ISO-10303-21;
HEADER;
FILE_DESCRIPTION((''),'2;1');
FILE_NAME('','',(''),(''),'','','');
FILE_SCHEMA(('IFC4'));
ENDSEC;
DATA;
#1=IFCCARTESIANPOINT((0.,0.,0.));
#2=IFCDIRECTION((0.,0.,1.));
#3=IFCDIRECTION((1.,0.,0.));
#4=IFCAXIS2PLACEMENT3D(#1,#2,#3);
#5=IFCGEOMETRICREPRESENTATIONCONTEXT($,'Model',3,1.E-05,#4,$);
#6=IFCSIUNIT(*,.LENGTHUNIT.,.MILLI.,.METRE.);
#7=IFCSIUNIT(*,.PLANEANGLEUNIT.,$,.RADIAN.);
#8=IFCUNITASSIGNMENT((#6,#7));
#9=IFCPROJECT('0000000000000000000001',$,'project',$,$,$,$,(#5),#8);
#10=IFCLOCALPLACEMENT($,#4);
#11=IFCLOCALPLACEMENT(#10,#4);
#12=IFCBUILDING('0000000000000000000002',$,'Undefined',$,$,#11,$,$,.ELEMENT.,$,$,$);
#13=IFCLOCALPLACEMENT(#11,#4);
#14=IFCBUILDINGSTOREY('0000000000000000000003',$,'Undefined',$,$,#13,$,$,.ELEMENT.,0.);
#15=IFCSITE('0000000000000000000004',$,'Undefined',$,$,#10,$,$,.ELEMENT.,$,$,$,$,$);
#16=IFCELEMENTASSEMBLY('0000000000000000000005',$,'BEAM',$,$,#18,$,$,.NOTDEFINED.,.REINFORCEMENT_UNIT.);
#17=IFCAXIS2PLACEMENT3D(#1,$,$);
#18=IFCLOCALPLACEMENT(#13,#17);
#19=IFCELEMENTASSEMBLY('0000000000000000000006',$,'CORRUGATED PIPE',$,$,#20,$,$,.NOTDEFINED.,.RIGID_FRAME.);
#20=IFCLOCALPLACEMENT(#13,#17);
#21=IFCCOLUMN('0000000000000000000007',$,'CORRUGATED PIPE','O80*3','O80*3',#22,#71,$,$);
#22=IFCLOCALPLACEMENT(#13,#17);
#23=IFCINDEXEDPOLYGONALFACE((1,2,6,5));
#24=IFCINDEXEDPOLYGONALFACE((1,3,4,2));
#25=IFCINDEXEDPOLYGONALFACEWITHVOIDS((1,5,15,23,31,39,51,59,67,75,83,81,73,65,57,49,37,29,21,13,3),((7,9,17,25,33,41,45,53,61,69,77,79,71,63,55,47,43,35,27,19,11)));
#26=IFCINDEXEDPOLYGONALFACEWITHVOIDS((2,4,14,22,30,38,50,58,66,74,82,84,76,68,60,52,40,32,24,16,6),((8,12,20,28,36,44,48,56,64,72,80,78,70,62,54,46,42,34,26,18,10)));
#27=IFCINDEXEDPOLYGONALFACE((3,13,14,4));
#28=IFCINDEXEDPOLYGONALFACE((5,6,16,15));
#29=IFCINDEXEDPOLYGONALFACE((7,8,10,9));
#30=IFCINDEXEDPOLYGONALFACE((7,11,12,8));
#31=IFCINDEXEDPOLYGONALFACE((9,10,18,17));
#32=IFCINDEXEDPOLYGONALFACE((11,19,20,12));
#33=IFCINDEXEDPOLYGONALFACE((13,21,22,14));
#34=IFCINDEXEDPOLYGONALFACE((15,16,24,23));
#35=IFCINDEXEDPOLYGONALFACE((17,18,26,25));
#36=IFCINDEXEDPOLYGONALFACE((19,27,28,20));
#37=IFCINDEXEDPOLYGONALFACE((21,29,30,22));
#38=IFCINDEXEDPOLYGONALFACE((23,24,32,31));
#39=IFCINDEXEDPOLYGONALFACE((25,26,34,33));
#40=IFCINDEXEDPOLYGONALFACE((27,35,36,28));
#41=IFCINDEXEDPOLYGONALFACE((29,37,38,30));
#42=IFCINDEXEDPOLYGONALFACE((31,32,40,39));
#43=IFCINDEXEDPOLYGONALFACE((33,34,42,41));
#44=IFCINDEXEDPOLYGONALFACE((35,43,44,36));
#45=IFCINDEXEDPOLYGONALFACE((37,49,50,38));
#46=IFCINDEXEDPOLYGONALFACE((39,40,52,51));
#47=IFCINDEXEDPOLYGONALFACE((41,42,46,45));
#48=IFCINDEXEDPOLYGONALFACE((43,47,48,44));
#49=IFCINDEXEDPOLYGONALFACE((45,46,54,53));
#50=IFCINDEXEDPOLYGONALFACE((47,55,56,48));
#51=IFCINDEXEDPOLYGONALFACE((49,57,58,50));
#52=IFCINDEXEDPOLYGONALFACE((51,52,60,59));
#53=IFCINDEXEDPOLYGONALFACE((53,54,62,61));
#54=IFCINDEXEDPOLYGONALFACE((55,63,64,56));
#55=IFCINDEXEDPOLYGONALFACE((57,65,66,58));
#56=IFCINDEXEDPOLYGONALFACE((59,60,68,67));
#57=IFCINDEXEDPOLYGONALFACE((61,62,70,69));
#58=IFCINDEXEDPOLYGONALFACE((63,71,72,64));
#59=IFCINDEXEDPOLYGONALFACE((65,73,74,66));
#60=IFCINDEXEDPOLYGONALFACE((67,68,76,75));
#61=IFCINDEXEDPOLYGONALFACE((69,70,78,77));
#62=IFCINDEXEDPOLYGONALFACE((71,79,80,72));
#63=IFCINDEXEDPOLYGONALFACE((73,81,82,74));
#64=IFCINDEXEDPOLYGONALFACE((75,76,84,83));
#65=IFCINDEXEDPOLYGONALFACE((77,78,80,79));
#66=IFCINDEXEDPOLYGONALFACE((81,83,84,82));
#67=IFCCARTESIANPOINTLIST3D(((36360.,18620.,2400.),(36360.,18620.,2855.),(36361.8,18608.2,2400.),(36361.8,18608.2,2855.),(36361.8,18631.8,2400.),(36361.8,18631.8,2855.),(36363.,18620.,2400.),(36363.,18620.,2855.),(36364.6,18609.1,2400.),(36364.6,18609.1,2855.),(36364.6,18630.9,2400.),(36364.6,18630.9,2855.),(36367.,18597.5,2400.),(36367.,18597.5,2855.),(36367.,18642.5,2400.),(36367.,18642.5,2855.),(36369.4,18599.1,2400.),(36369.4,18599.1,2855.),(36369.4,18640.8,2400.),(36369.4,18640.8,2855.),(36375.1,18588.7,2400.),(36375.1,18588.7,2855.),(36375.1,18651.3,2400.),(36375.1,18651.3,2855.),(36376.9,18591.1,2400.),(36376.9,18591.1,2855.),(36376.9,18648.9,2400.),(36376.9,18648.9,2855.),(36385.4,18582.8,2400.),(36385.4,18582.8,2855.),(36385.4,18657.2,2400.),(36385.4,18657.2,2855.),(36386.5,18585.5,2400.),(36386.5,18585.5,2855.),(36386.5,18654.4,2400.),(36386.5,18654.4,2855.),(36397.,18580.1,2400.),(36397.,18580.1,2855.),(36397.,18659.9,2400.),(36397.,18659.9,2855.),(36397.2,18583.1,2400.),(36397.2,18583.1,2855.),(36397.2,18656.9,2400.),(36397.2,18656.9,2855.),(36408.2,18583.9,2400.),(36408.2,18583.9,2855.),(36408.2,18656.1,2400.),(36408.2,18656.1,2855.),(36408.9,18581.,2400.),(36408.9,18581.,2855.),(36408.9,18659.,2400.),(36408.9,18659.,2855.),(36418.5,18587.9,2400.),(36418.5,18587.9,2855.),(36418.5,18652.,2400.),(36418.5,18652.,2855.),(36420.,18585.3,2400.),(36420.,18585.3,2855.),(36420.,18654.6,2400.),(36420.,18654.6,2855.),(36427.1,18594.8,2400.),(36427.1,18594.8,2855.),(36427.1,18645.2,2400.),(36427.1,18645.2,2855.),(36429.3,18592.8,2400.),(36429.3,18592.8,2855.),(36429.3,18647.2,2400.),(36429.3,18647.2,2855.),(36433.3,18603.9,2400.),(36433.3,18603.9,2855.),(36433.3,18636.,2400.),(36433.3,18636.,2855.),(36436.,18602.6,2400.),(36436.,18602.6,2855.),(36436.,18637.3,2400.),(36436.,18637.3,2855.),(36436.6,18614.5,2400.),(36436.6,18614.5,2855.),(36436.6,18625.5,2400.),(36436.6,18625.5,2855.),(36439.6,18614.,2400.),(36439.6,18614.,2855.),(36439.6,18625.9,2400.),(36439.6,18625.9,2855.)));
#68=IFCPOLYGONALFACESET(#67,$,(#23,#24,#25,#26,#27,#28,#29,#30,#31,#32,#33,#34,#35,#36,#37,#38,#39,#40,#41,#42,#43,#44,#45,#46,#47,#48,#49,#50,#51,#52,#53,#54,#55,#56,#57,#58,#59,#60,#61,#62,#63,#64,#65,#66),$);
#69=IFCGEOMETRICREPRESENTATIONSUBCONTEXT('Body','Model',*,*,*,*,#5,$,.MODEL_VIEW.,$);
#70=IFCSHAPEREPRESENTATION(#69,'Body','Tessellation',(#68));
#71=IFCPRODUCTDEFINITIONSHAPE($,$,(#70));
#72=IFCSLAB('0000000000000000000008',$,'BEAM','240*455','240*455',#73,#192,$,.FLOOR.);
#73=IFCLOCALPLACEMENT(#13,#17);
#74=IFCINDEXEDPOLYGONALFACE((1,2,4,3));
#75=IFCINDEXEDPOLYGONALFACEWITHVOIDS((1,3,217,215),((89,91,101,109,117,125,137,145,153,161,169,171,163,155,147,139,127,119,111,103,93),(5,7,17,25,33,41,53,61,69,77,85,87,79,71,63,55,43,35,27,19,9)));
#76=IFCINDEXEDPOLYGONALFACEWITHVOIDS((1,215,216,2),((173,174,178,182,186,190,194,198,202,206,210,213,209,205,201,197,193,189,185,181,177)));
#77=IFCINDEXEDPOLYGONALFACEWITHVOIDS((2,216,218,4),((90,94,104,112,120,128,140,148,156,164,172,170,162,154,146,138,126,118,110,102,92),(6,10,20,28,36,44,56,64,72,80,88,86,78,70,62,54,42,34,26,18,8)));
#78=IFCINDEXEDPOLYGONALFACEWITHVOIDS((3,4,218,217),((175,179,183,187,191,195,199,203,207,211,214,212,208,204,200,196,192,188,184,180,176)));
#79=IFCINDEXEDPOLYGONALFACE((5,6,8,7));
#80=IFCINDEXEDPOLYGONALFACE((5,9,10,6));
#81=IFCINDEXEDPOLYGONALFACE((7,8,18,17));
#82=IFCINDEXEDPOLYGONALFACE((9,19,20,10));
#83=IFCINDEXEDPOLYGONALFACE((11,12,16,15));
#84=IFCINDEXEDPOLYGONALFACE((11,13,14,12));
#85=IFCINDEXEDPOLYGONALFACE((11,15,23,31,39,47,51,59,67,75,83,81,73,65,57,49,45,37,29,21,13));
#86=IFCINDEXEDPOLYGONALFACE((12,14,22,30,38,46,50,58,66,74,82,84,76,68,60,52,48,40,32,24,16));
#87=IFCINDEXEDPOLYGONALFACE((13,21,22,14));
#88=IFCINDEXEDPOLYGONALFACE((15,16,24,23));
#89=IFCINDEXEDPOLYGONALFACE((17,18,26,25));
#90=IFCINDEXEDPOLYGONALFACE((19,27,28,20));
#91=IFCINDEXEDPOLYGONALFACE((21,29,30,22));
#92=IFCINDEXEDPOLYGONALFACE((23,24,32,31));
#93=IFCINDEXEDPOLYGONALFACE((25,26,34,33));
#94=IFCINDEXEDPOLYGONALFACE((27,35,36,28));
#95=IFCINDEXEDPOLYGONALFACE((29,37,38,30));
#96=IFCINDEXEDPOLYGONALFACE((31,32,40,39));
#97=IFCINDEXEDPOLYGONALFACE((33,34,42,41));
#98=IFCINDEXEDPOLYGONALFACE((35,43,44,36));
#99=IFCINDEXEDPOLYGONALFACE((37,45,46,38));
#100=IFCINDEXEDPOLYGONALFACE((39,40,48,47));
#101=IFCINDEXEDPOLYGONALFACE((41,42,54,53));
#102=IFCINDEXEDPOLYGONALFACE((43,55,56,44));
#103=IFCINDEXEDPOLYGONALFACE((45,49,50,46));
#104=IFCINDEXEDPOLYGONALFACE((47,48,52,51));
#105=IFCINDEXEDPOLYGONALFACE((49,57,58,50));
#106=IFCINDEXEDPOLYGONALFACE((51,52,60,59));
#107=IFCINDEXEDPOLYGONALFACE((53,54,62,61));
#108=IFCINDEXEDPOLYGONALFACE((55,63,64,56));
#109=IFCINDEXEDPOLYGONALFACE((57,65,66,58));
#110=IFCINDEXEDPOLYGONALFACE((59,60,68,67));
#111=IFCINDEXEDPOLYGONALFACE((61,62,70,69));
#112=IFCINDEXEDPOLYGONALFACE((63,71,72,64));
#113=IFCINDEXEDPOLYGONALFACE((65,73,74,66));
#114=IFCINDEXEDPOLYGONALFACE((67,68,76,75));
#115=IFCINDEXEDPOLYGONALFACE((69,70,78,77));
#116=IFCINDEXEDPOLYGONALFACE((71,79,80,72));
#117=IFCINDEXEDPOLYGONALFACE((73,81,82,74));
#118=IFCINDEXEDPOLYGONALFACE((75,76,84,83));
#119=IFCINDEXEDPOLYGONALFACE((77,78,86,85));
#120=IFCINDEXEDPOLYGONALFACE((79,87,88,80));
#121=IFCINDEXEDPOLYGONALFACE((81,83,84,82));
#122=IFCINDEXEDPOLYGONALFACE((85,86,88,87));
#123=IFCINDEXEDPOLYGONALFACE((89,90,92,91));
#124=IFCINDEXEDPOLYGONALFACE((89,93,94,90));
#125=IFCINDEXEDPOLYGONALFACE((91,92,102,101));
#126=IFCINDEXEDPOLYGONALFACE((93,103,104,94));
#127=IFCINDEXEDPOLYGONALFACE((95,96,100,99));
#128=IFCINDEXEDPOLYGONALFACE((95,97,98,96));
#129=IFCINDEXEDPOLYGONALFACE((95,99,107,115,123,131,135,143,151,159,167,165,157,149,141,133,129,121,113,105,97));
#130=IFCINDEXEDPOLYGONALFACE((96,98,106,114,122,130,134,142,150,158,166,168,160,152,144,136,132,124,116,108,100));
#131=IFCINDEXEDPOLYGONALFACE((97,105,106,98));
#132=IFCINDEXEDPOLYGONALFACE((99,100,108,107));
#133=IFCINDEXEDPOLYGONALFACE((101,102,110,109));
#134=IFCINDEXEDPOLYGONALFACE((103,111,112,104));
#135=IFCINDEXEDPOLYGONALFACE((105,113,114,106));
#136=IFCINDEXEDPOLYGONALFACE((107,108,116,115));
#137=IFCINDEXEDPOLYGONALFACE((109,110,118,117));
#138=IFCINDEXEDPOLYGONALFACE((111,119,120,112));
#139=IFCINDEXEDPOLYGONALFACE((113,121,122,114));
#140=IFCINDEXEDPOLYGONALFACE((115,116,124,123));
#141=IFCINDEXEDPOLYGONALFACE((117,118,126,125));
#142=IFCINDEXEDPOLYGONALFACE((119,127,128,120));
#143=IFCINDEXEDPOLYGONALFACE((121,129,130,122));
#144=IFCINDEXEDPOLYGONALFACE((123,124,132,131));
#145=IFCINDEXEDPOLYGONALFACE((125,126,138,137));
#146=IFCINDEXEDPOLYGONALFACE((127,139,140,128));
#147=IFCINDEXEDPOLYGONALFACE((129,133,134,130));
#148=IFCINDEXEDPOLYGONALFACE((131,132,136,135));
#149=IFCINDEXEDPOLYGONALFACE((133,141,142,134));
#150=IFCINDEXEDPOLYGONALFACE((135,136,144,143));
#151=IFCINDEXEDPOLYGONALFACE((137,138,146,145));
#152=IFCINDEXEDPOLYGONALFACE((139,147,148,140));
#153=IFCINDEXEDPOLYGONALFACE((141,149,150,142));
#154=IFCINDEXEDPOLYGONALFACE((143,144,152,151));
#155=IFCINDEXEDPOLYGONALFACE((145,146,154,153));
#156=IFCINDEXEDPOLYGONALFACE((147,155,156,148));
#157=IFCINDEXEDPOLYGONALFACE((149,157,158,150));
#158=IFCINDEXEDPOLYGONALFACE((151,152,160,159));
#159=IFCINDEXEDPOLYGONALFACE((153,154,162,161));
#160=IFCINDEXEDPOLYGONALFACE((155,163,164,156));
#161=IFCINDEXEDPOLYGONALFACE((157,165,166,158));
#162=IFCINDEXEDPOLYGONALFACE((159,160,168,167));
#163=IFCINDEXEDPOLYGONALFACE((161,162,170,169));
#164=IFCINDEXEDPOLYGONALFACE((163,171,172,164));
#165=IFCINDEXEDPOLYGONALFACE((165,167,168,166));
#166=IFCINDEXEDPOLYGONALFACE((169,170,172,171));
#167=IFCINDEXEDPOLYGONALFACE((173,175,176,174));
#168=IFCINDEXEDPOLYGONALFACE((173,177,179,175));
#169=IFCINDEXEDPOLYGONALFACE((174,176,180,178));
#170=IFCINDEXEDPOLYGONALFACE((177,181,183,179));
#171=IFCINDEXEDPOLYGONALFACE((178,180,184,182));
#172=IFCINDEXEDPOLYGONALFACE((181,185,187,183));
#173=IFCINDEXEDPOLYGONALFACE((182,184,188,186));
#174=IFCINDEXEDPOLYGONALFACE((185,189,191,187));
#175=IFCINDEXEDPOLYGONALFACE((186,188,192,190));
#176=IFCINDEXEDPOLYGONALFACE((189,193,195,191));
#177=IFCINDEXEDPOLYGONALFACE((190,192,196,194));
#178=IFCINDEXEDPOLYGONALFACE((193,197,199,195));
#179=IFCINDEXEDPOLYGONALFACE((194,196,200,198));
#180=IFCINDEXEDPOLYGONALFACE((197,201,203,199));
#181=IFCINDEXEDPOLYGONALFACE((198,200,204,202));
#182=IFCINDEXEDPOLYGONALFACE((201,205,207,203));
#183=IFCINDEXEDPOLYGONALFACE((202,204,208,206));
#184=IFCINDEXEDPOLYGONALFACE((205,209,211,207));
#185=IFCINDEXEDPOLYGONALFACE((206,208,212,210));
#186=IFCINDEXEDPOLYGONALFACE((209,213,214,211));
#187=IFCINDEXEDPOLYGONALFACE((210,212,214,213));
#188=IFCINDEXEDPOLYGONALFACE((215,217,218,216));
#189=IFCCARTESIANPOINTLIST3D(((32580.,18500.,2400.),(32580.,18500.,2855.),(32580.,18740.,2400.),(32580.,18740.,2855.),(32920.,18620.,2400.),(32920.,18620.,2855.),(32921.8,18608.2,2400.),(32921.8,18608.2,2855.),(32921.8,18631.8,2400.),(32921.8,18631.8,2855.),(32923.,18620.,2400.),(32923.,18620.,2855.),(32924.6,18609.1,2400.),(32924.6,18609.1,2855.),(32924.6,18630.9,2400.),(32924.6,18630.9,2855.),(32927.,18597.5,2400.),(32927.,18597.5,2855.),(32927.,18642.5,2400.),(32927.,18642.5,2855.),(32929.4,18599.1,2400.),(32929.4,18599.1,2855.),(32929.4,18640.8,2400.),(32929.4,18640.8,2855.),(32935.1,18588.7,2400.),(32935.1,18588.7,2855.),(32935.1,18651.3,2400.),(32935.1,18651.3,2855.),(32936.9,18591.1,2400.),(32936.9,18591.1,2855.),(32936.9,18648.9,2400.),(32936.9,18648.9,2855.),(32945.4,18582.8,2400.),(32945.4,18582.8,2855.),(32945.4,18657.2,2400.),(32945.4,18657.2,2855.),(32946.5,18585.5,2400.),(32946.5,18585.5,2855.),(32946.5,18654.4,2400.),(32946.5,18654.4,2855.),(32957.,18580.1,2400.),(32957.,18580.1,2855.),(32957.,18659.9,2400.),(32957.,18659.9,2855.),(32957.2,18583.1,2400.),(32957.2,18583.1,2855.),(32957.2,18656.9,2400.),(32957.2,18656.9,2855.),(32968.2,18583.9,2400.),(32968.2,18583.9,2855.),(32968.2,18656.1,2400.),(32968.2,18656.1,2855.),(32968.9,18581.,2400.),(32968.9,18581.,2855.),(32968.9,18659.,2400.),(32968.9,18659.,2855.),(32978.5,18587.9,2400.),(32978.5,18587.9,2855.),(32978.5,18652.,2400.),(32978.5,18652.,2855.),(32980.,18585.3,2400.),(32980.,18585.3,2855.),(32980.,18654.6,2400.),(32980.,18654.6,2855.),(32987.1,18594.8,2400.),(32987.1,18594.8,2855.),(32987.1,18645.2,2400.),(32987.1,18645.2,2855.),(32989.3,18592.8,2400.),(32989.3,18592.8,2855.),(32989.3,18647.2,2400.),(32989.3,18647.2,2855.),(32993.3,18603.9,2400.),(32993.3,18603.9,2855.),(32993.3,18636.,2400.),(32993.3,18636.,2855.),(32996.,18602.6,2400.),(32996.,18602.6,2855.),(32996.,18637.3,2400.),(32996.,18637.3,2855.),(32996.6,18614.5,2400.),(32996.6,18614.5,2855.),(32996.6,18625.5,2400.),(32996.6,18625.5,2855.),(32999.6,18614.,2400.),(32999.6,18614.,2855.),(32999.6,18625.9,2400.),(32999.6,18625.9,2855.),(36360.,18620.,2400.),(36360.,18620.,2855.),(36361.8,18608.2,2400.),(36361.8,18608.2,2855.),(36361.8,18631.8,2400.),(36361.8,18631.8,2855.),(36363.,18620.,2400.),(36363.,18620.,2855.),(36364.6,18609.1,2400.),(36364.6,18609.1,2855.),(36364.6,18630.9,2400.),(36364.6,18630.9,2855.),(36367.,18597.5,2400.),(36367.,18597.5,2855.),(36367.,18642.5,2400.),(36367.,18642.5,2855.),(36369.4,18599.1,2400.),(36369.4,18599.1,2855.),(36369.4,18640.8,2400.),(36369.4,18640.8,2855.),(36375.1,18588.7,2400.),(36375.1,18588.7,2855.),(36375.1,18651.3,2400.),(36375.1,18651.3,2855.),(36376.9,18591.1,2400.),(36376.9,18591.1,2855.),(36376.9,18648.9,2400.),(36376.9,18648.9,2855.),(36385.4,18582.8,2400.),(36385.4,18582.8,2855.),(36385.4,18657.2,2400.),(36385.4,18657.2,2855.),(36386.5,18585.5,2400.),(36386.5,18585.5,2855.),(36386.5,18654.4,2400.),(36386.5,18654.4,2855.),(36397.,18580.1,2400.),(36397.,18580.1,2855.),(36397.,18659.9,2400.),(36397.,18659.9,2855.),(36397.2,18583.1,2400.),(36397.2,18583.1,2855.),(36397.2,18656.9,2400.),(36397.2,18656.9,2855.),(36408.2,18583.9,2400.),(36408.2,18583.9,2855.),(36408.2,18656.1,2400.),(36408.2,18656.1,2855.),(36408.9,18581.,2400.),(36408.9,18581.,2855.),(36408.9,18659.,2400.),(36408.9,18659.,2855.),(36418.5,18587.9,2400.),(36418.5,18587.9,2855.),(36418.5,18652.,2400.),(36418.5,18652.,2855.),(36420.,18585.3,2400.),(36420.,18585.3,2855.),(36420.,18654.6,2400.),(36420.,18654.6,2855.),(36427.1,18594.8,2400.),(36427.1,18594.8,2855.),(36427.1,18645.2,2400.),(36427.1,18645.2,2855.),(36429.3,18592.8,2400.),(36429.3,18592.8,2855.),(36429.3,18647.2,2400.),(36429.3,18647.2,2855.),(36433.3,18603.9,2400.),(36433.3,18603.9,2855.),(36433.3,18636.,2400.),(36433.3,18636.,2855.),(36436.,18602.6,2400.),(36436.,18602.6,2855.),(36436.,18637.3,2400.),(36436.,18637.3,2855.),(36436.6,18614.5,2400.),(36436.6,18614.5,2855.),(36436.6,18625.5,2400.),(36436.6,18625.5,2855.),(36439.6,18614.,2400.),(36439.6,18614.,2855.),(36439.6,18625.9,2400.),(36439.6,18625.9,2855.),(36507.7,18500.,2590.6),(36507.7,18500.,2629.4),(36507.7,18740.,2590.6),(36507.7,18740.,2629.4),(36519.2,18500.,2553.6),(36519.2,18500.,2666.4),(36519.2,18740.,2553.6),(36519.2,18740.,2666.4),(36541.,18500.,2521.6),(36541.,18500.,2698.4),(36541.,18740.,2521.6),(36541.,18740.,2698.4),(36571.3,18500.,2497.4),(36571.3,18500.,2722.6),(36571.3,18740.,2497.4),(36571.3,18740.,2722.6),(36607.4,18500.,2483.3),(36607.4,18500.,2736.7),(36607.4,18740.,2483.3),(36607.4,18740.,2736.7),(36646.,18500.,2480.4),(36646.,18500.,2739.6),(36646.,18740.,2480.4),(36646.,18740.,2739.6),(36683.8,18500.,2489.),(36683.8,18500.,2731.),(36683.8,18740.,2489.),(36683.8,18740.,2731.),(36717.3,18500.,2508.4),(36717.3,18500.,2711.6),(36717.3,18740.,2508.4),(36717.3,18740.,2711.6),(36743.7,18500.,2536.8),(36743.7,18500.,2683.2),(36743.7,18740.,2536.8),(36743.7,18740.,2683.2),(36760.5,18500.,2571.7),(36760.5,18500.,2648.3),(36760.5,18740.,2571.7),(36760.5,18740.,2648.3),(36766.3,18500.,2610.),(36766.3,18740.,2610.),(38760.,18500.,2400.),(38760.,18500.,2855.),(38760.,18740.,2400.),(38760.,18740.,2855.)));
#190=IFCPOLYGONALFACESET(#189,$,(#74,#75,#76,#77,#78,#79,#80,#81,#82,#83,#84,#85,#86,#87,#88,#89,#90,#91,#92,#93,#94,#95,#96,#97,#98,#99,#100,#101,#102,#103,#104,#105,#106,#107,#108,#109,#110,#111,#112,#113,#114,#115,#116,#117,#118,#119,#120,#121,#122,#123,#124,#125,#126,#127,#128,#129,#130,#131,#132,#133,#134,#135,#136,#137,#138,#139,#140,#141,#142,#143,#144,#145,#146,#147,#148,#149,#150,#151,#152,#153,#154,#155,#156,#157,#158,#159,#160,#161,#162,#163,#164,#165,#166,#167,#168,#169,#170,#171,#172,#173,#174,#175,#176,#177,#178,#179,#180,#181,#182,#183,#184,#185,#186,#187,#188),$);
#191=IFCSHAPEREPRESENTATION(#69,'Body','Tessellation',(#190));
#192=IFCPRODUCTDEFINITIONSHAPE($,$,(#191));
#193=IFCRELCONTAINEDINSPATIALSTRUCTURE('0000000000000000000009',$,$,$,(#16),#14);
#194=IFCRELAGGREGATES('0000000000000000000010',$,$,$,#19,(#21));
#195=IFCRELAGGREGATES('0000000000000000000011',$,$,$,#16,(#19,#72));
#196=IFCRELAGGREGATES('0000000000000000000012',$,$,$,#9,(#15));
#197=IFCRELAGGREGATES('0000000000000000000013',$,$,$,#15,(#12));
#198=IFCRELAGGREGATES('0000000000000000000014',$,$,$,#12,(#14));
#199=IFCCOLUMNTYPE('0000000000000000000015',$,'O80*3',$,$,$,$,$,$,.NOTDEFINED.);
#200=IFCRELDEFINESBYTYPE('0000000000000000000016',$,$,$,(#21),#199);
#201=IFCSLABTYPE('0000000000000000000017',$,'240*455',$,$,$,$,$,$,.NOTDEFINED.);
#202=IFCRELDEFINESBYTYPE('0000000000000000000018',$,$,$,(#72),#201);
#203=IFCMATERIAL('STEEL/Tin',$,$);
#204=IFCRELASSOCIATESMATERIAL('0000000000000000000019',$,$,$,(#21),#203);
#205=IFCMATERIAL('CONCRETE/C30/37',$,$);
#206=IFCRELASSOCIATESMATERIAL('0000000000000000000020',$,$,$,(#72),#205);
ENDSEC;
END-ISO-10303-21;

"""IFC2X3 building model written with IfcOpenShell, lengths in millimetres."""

from ifc_helpers import new_model, si_unit, frame, origin_with_axes, origin_2d_with_axis, place, context, subcontext, project, spatial, polyline, circle, hollow_circle, outline, extrude, boolean, material, type_object, element, aggregate, save


model = new_model("IFC2X3")

# Units and contexts
model_context = context("Model", 3, precision=1e-05, world=origin_with_axes())
body_context = subcontext(model_context, "Body", "Model", "MODEL_VIEW")
ifc_project = project(units=[si_unit("LENGTHUNIT", "METRE", prefix="MILLI"), si_unit("PLANEANGLEUNIT", "RADIAN")], contexts=[model_context])

# Site, building, storey
site_placement = place(None, origin_with_axes())
site = spatial("IfcSite", under=ifc_project, at=site_placement, Name="Undefined", CompositionType="ELEMENT")
building_placement = place(site_placement, origin_with_axes())
building = spatial("IfcBuilding", under=site, at=building_placement, Name="Undefined", CompositionType="ELEMENT")
storey_placement = place(building_placement, origin_with_axes())
storey = spatial("IfcBuildingStorey", under=building, at=storey_placement, Name="Undefined", CompositionType="ELEMENT", Elevation=0.0)

# Element assemblies, column, slab
assembly_1_placement = place(storey_placement, origin_with_axes())
assembly_1 = element("IfcElementAssembly", 1, at=assembly_1_placement, inside=storey, Name="BEAM", AssemblyPlace="NOTDEFINED", PredefinedType="REINFORCEMENT_UNIT")
assembly_2_placement = place(assembly_1_placement, origin_with_axes())
assembly_2 = element("IfcElementAssembly", 2, at=assembly_2_placement, Name="CORRUGATED PIPE", AssemblyPlace="NOTDEFINED", PredefinedType="RIGID_FRAME")
ifc_material_1 = material(Name="STEEL/Tin")
column_type = type_object("IfcColumnType", Name="O80*3", PredefinedType="NOTDEFINED")
column_placement = place(assembly_2_placement, frame((36400.0, 18620.0, 2400.0), z_axis=(0.0, 0.0, 1.0), x_axis=(0.0, 1.0, 0.0)))
column = element("IfcColumn", 3, at=column_placement, type_object=column_type, material=ifc_material_1, Name="CORRUGATED PIPE", Description="O80*3", ObjectType="O80*3", context=body_context, shape_type="SweptSolid", body=[
    extrude(hollow_circle(Radius=40.0, WallThickness=3.0, at=origin_2d_with_axis()), frame((0.0, 0.0, 455.0), z_axis=(0.0, 0.0, -1.0), x_axis=(0.0, 1.0, 0.0)), (0.0, 0.0, 1.0), 455.0),
])
aggregate(assembly_2, [column])
ifc_material_2 = material(Name="CONCRETE/C30/37")
slab_type = type_object("IfcSlabType", Name="240*455", PredefinedType="NOTDEFINED")
slab_placement = place(assembly_1_placement, frame((38760.0, 18620.0, 2400.0), z_axis=(0.0, -1.0, 0.0), x_axis=(0.0, 0.0, 1.0)))
slab = element("IfcSlab", 4, at=slab_placement, type_object=slab_type, material=ifc_material_2, Name="BEAM", Description="240*455", ObjectType="240*455", PredefinedType="FLOOR", context=body_context, shape_type="CSG", body=[
    boolean("DIFFERENCE", boolean("DIFFERENCE", boolean("DIFFERENCE", extrude(outline(polyline([(0.0, 0.0), (455.0, 0.0), (455.0, 6180.0), (0.0, 6180.0), (0.0, 0.0)])), frame((0.0, 0.0, -120.0), z_axis=(0.0, 0.0, 1.0), x_axis=(1.0, 0.0, 0.0)), (0.0, 0.0, 1.0), 240.0), extrude(circle(Radius=130.0, at=origin_2d_with_axis()), frame((210.0, 2123.7, -125.0), z_axis=(0.0, -0.000001, 1.0), x_axis=(0.0, -1.0, -0.000001)), (0.0, 0.0, 1.0), 250.0)), extrude(hollow_circle(Radius=40.0, WallThickness=3.0, at=origin_2d_with_axis()), frame((455.0, 2360.0, 0.0), z_axis=(-1.0, 0.0, 0.0), x_axis=(0.0, 1.0, 0.0)), (0.0, 0.0, 1.0), 455.0)), extrude(hollow_circle(Radius=40.0, WallThickness=3.0, at=origin_2d_with_axis()), frame((455.0, 5800.0, 0.0), z_axis=(-1.0, 0.0, 0.0), x_axis=(0.0, 1.0, 0.0)), (0.0, 0.0, 1.0), 455.0)),
])
aggregate(assembly_1, [assembly_2, slab])

save(model, "model.ifc")
